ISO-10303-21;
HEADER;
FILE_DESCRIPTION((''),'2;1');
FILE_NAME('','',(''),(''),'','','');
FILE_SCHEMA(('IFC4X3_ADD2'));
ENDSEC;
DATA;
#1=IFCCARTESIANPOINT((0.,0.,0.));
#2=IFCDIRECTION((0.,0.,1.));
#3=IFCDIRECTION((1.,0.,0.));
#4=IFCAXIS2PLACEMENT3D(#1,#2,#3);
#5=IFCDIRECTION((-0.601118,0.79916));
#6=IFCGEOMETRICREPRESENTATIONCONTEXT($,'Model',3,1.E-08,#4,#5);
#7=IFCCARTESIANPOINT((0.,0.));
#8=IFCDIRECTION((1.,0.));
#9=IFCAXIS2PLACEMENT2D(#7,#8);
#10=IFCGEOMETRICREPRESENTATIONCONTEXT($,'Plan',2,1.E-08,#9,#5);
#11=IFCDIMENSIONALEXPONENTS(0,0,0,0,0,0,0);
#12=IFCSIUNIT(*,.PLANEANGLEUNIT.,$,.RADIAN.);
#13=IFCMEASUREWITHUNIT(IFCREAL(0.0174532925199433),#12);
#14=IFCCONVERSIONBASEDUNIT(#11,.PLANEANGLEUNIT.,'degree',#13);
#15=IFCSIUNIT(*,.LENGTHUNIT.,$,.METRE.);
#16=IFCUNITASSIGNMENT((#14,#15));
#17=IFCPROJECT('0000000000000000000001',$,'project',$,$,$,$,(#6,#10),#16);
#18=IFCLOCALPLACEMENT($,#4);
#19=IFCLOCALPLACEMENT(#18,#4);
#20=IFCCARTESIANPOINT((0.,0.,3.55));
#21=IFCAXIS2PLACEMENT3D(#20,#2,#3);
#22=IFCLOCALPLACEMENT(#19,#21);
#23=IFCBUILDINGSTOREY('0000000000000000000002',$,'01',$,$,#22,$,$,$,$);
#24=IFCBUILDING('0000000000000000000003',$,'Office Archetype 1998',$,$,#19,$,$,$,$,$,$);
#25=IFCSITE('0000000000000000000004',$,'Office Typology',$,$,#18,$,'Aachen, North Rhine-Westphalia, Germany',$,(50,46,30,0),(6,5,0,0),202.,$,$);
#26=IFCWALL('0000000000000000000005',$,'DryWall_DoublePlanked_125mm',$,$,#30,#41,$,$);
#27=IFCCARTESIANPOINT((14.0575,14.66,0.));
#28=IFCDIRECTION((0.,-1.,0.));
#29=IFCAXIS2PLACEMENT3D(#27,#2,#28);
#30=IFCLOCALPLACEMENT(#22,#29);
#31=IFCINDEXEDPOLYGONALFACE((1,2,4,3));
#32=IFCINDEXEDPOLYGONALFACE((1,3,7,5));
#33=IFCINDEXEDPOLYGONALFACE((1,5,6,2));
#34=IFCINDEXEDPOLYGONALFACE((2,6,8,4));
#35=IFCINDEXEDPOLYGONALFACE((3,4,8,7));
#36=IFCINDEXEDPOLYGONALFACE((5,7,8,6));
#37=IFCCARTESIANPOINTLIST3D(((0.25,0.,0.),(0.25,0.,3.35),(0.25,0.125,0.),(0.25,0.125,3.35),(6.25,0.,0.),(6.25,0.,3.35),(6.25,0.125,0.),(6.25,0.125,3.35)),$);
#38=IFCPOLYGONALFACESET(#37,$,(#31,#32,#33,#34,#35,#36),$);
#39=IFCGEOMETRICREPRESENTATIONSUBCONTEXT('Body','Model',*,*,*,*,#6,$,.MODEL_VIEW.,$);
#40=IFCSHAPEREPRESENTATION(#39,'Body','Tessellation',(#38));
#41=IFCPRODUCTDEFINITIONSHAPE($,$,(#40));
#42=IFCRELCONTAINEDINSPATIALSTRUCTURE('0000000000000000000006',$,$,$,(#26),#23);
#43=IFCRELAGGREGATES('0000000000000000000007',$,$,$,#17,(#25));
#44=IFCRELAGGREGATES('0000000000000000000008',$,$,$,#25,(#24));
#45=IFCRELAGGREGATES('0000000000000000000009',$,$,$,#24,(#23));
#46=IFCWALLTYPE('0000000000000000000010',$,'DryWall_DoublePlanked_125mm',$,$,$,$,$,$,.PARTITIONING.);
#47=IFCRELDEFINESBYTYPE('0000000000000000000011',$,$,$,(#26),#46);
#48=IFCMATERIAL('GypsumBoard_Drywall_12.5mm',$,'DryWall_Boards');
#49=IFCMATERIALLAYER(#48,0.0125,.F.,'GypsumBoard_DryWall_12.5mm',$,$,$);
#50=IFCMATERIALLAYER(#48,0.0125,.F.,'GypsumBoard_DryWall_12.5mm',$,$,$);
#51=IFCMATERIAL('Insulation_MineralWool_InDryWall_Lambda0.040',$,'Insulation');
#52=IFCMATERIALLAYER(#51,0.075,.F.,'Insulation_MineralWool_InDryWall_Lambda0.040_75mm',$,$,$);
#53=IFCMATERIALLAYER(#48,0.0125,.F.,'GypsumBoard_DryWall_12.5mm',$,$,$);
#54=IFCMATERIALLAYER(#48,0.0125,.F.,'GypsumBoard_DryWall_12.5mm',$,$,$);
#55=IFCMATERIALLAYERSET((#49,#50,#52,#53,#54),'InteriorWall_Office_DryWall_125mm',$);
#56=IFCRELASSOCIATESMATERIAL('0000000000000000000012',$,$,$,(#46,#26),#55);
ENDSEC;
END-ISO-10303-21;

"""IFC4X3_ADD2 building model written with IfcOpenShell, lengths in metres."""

from ifc_helpers import new_model, entity, si_unit, converted_unit, direction, frame, origin_with_axes, origin_2d_with_axis, place, context, subcontext, project, spatial, line, indexed_curve, outline, extrude, material, layer, layer_set, layer_usage, type_object, element, save


model = new_model("IFC4X3_ADD2")

# Units and contexts
model_context = context("Model", 3, precision=1e-08, world=origin_with_axes(), true_north=direction((-0.601118, 0.79916)))
plan_context = context("Plan", 2, precision=1e-08, world=origin_2d_with_axis(), true_north=direction((-0.601118, 0.79916)))
body_context = subcontext(model_context, "Body", "Model", "MODEL_VIEW")
ifc_project = project(units=[converted_unit("PLANEANGLEUNIT", "degree", entity("IfcReal", 0.0174532925199433), si_unit("PLANEANGLEUNIT", "RADIAN"), dimensions=[0, 0, 0, 0, 0, 0, 0]), si_unit("LENGTHUNIT", "METRE")], contexts=[model_context, plan_context])

# Site, building, storey
site_placement = place(None, origin_with_axes())
site = spatial("IfcSite", under=ifc_project, at=site_placement, Name="Office Typology", LongName="Aachen, North Rhine-Westphalia, Germany", RefLatitude=(50, 46, 30, 0), RefLongitude=(6, 5, 0, 0), RefElevation=202.0)
building_placement = place(site_placement, origin_with_axes())
building = spatial("IfcBuilding", under=site, at=building_placement, Name="Office Archetype 1998")
storey_placement = place(building_placement, frame((0.0, 0.0, 3.55), z_axis=(0.0, 0.0, 1.0), x_axis=(1.0, 0.0, 0.0)))
storey = spatial("IfcBuildingStorey", under=building, at=storey_placement, Name="01")

# Wall
ifc_material_1 = material(Name="GypsumBoard_Drywall_12.5mm", Category="DryWall_Boards")
ifc_layer_1 = layer(ifc_material_1, 0.0125, ventilated=False, Name="GypsumBoard_DryWall_12.5mm")
ifc_layer_2 = layer(ifc_material_1, 0.0125, ventilated=False, Name="GypsumBoard_DryWall_12.5mm")
ifc_material_2 = material(Name="Insulation_MineralWool_InDryWall_Lambda0.040", Category="Insulation")
ifc_layer_3 = layer(ifc_material_2, 0.075, ventilated=False, Name="Insulation_MineralWool_InDryWall_Lambda0.040_75mm")
ifc_layer_4 = layer(ifc_material_1, 0.0125, ventilated=False, Name="GypsumBoard_DryWall_12.5mm")
ifc_layer_5 = layer(ifc_material_1, 0.0125, ventilated=False, Name="GypsumBoard_DryWall_12.5mm")
ifc_layer_set_1 = layer_set([ifc_layer_1, ifc_layer_2, ifc_layer_3, ifc_layer_4, ifc_layer_5], Name="InteriorWall_Office_DryWall_125mm")
ifc_layer_usage = layer_usage(ifc_layer_set_1, "AXIS2", "POSITIVE", 0.0)
wall_type_1 = type_object("IfcWallType", Name="DryWall_DoublePlanked_125mm", PredefinedType="PARTITIONING", material=ifc_layer_set_1)
wall_1_placement = place(storey_placement, frame((14.0575, 14.66, 0.0), z_axis=(0.0, 0.0, 1.0), x_axis=(0.0, -1.0, 0.0)))
element("IfcWall", 1, at=wall_1_placement, inside=storey, type_object=wall_type_1, material=ifc_layer_usage, Name="DryWall_DoublePlanked_125mm", context=body_context, shape_type="SweptSolid", body=[
    extrude(outline(indexed_curve([(0.25, 0.0), (0.25, 0.125), (6.25, 0.125), (6.25, 0.0)], segments=[line(1, 2, 3, 4, 1)])), origin_with_axes(), (0.0, 0.0, 1.0), 3.35),
])

save(model, "model.ifc")
